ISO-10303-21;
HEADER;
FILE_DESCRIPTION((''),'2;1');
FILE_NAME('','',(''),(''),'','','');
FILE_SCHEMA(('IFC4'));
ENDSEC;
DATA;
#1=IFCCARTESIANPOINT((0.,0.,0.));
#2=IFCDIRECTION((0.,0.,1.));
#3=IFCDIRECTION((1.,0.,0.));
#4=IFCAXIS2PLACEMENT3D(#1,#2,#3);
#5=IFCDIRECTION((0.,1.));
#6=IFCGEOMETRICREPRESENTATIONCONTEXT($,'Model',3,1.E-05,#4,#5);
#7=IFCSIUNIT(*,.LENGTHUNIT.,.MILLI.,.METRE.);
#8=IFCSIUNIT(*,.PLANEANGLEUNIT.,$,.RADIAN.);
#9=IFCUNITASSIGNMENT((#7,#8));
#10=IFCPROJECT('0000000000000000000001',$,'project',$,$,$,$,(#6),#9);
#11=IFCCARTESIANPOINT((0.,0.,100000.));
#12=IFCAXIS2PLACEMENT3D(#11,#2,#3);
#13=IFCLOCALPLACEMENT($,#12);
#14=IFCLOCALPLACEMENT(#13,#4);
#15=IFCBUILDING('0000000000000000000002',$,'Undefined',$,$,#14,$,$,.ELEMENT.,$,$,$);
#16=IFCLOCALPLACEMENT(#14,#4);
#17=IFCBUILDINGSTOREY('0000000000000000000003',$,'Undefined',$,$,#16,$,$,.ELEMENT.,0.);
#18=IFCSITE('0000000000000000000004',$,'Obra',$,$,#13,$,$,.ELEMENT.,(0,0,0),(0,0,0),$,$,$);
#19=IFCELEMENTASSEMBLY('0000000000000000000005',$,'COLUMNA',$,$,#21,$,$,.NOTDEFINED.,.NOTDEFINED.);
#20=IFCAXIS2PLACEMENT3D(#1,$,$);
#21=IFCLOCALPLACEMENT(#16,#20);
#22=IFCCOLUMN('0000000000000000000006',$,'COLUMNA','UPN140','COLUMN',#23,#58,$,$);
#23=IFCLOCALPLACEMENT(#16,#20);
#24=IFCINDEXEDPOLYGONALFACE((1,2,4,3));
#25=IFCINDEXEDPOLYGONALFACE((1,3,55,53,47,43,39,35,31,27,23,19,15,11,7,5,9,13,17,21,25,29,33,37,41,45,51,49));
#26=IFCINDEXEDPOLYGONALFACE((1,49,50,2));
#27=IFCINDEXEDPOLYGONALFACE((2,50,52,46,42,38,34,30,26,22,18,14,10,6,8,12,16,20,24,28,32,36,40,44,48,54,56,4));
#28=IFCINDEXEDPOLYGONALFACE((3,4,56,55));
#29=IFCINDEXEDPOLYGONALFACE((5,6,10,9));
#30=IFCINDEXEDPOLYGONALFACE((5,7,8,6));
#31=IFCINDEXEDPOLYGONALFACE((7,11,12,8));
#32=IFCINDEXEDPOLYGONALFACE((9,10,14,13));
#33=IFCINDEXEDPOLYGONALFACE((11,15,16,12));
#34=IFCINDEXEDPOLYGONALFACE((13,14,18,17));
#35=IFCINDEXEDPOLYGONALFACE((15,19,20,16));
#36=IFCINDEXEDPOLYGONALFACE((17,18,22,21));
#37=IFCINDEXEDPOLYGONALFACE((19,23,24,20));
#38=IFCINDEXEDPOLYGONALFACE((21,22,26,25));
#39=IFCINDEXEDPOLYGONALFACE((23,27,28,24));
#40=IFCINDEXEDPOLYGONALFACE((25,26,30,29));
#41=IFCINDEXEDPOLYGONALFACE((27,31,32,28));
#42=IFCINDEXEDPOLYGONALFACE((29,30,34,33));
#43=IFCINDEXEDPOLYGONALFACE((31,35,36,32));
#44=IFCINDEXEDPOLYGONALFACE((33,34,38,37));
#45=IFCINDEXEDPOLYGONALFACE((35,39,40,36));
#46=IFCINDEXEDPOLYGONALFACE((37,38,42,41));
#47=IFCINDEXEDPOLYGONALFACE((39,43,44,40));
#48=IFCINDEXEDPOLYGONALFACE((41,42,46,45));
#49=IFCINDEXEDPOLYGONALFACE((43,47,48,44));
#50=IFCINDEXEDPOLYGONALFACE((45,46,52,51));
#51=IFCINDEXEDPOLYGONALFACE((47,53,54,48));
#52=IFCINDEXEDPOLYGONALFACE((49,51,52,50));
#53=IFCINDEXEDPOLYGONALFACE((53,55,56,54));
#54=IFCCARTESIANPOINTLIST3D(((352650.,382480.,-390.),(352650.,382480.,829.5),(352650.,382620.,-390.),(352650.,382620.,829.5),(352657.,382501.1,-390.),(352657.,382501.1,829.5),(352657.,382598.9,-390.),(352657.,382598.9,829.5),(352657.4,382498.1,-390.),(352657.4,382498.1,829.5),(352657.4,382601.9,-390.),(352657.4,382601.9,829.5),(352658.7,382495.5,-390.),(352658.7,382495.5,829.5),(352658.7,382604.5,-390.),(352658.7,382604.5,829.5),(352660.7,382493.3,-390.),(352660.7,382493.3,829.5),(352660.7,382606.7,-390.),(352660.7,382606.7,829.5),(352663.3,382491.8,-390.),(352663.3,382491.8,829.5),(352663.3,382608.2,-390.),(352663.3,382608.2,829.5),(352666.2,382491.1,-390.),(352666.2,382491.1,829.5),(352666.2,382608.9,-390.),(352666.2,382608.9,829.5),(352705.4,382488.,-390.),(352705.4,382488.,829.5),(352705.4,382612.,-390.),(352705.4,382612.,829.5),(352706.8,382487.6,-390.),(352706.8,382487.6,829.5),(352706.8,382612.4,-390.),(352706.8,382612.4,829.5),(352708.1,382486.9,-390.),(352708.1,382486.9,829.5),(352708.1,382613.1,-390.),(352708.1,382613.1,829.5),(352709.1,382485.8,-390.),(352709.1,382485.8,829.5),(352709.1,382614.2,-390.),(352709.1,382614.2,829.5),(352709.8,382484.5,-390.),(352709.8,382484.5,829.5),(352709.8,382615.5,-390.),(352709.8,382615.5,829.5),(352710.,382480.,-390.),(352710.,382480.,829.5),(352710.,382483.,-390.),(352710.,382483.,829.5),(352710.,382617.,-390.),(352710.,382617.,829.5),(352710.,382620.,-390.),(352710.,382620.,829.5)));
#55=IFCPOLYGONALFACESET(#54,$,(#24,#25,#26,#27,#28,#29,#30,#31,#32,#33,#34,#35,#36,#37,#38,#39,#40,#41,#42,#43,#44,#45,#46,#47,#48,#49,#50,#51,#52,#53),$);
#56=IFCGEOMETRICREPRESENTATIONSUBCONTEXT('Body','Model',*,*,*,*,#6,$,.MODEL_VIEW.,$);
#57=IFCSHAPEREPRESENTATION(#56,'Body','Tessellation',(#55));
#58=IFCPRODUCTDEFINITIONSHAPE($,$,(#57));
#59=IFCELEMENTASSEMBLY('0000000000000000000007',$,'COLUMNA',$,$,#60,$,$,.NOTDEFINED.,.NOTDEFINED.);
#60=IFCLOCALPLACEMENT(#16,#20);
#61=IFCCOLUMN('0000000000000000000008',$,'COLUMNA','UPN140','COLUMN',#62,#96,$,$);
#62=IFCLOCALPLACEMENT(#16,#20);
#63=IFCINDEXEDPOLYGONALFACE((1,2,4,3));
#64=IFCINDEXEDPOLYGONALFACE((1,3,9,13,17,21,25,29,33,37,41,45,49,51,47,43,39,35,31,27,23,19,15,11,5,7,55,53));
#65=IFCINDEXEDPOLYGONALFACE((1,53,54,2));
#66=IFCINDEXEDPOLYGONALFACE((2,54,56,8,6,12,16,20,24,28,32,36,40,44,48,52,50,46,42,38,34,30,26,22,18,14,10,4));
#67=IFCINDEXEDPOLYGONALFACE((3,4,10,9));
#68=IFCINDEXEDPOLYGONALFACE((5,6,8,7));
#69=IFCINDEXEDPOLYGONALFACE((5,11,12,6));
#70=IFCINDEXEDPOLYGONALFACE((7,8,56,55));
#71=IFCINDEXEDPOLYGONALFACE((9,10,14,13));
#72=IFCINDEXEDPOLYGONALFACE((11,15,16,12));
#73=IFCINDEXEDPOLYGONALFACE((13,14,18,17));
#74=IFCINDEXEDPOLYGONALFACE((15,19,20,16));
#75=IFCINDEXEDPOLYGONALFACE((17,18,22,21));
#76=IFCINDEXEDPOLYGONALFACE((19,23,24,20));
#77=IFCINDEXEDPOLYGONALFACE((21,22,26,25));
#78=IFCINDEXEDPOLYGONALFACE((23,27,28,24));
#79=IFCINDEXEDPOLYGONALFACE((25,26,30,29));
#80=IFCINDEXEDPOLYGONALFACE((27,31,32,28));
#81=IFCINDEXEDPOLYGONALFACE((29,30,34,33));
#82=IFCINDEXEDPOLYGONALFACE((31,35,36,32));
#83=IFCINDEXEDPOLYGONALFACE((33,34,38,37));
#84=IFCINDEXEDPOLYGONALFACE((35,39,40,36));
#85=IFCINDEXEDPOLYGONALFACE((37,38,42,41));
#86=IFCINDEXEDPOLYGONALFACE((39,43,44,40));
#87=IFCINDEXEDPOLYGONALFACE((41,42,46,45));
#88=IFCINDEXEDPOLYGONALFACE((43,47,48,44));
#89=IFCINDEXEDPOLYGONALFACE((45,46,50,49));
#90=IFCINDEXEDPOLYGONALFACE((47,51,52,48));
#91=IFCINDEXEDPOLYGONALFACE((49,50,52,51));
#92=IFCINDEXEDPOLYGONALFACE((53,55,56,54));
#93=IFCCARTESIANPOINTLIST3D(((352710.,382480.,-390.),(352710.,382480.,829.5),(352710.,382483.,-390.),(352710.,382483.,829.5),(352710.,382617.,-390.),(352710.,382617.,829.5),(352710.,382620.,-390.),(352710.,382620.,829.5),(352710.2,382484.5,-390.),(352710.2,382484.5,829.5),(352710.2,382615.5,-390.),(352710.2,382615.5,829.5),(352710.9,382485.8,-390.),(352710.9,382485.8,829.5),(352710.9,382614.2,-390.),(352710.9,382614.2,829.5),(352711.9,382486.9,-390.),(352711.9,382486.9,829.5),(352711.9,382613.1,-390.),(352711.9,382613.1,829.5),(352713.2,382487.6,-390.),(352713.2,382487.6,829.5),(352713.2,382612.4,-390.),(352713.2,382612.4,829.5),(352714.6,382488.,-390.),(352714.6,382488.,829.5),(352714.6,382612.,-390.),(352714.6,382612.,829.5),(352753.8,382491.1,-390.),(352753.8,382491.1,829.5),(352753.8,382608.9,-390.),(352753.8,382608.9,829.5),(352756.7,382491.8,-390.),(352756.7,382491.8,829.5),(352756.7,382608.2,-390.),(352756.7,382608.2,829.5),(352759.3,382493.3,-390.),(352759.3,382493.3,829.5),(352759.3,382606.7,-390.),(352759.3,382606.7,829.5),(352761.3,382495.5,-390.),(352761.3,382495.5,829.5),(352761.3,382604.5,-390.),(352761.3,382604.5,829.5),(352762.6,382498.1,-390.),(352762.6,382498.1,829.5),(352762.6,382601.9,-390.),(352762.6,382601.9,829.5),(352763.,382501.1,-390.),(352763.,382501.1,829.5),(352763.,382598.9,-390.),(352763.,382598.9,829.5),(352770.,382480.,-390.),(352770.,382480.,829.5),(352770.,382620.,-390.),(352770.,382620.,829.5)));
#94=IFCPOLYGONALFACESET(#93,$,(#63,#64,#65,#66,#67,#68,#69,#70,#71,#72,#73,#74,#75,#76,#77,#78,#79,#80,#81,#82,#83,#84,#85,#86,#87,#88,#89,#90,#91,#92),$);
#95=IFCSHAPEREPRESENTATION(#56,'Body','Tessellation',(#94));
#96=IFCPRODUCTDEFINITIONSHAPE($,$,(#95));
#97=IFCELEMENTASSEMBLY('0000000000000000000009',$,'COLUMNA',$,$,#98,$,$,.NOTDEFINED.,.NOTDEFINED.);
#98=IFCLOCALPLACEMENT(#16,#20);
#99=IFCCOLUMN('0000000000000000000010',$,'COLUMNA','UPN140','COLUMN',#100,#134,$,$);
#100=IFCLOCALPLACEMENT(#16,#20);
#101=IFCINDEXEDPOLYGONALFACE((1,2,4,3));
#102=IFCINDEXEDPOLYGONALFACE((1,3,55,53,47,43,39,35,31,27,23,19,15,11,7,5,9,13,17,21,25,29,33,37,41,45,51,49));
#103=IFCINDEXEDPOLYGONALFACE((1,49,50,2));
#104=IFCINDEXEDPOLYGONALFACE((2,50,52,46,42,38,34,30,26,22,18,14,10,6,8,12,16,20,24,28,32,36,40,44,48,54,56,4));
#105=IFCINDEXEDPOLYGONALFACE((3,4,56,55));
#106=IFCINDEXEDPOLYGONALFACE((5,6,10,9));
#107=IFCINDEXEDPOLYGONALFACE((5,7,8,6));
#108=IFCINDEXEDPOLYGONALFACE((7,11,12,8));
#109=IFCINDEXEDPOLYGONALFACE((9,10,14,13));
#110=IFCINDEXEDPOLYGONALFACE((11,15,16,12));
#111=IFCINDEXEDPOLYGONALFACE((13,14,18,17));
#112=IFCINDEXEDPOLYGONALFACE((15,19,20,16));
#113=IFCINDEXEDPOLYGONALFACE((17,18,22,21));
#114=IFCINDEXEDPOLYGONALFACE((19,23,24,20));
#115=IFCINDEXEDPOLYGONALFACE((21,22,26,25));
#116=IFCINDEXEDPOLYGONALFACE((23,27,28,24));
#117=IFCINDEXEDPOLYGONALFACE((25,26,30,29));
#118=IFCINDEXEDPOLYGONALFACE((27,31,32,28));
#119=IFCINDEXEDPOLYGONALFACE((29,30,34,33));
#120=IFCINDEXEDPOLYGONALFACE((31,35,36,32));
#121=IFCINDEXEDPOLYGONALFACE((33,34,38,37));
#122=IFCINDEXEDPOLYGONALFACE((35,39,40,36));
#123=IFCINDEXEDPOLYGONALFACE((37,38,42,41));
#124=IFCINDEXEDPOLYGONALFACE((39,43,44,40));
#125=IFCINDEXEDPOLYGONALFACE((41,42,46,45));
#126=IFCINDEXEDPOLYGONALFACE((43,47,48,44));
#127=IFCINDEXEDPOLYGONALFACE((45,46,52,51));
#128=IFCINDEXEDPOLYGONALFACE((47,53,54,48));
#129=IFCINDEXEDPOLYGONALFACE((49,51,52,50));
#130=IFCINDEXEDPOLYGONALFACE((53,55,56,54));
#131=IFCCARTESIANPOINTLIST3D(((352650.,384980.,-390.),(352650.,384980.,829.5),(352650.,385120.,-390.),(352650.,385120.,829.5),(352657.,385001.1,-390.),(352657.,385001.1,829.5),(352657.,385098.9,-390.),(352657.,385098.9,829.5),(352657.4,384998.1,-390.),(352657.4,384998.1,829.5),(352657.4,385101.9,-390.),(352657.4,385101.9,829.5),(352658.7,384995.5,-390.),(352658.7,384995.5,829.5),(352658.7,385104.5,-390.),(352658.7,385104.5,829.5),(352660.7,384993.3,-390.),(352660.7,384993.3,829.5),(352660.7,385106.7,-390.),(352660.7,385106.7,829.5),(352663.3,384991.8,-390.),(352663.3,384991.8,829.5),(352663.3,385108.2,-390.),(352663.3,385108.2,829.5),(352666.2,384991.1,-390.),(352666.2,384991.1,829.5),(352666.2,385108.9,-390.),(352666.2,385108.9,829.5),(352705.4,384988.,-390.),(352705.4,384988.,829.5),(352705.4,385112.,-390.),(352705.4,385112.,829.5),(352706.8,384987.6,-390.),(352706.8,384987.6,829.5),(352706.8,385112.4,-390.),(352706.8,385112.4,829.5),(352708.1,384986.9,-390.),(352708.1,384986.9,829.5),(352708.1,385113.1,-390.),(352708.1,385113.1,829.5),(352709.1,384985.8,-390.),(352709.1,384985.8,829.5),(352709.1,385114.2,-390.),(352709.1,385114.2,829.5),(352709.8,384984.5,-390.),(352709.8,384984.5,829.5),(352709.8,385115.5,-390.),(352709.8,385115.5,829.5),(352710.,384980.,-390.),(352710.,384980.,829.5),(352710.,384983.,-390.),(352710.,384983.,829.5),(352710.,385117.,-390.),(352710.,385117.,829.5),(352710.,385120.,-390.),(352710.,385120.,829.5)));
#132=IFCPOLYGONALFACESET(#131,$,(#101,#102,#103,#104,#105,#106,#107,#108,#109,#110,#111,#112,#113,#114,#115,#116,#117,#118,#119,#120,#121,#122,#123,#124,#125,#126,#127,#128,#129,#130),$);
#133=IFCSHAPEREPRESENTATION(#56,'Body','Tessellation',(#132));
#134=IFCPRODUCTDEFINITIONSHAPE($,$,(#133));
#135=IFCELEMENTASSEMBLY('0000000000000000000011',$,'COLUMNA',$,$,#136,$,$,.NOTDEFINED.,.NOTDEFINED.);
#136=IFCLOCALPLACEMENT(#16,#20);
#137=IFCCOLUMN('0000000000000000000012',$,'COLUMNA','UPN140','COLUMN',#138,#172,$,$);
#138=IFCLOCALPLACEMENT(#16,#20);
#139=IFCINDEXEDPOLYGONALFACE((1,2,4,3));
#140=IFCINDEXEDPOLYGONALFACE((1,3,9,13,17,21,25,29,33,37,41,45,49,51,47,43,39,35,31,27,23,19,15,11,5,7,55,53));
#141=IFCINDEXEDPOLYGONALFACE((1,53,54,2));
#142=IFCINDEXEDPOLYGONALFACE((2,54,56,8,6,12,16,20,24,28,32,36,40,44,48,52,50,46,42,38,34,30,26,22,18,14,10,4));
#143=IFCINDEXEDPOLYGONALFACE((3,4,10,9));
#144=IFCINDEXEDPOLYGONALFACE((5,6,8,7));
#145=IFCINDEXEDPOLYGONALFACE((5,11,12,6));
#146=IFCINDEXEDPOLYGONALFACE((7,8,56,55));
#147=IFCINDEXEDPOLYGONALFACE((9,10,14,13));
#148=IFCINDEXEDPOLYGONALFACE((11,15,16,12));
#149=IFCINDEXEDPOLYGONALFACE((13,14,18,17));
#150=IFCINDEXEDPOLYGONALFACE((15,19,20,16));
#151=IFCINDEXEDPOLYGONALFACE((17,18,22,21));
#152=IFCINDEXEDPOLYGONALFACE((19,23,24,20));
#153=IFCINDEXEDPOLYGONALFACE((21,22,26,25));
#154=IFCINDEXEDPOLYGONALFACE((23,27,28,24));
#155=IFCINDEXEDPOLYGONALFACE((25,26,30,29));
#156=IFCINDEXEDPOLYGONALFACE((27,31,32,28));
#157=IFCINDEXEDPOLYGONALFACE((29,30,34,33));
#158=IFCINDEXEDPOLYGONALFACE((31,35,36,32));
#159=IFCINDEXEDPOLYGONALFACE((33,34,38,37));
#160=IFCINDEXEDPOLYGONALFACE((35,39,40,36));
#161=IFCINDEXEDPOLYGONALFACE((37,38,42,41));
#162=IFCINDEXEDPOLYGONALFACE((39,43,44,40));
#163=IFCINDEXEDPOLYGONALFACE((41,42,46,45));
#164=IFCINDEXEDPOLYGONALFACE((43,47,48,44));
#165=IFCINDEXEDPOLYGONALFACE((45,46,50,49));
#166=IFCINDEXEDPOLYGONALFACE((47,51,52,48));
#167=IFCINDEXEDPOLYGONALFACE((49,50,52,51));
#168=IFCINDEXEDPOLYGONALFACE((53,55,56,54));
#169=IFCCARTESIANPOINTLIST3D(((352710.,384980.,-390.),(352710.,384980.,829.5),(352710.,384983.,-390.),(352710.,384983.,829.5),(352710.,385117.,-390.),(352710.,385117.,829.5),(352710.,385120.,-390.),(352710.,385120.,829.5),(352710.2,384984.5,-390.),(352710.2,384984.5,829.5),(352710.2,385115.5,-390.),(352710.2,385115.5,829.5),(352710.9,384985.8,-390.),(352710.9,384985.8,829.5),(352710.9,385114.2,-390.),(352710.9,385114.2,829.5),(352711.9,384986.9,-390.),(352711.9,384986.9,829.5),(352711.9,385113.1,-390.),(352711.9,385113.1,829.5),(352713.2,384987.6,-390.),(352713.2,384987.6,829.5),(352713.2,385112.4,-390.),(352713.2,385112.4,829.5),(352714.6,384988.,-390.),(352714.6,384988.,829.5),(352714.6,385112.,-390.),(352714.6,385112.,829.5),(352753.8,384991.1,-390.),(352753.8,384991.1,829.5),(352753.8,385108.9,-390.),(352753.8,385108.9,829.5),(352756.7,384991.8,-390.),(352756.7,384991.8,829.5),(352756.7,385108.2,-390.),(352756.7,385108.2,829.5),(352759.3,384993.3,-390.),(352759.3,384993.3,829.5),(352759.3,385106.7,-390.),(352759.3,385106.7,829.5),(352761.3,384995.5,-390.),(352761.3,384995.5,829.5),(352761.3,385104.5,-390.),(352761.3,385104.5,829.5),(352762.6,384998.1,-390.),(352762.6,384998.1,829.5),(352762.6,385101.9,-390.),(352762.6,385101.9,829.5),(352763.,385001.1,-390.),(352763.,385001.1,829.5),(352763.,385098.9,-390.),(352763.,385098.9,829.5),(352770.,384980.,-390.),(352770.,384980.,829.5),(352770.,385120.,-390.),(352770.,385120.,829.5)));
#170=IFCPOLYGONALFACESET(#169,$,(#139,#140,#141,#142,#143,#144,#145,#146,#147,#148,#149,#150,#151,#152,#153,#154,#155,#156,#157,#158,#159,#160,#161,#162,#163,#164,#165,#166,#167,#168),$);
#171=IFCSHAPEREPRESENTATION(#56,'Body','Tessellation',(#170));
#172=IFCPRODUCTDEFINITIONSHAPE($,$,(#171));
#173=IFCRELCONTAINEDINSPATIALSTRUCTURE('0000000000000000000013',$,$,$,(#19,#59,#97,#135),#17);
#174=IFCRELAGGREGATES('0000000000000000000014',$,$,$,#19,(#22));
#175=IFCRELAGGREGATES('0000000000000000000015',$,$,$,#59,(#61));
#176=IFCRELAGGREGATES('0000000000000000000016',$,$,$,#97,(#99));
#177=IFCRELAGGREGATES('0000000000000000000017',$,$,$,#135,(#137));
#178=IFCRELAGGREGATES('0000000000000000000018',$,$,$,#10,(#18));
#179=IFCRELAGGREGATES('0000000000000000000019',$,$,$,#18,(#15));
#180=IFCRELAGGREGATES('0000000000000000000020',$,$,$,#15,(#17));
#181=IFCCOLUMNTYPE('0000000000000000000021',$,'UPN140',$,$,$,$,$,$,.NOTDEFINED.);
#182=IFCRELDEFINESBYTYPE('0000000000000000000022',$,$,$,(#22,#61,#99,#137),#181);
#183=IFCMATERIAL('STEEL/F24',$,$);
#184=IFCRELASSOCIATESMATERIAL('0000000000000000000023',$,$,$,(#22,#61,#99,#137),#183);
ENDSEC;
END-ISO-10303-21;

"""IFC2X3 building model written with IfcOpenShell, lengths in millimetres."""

from ifc_helpers import new_model, si_unit, direction, frame, origin_with_axes, origin_2d_with_axis, place, context, subcontext, project, spatial, u_section, extrude, material, type_object, element, aggregate, save


model = new_model("IFC2X3")

# Units and contexts
model_context = context("Model", 3, precision=1e-05, world=origin_with_axes(), true_north=direction((0.0, 1.0)))
body_context = subcontext(model_context, "Body", "Model", "MODEL_VIEW")
ifc_project = project(units=[si_unit("LENGTHUNIT", "METRE", prefix="MILLI"), si_unit("PLANEANGLEUNIT", "RADIAN")], contexts=[model_context])

# Site, building, storey
site_placement = place(None, frame((0.0, 0.0, 100000.0), z_axis=(0.0, 0.0, 1.0), x_axis=(1.0, 0.0, 0.0)))
site = spatial("IfcSite", under=ifc_project, at=site_placement, Name="Obra", CompositionType="ELEMENT", RefLatitude=(0, 0, 0), RefLongitude=(0, 0, 0))
building_placement = place(site_placement, origin_with_axes())
building = spatial("IfcBuilding", under=site, at=building_placement, Name="Undefined", CompositionType="ELEMENT")
storey_placement = place(building_placement, origin_with_axes())
storey = spatial("IfcBuildingStorey", under=building, at=storey_placement, Name="Undefined", CompositionType="ELEMENT", Elevation=0.0)

# Element assemblies, columns
ifc_material_1 = material(Name="STEEL/F24")
column_type_1 = type_object("IfcColumnType", Name="UPN140", PredefinedType="NOTDEFINED")
assembly_1_placement = place(storey_placement, origin_with_axes())
assembly_1 = element("IfcElementAssembly", 1, at=assembly_1_placement, inside=storey, Name="COLUMNA", AssemblyPlace="NOTDEFINED", PredefinedType="NOTDEFINED")
column_1_placement = place(assembly_1_placement, frame((352680.0, 382550.0, -390.0), z_axis=(0.0, 0.0, 1.0), x_axis=(0.0, -1.0, 0.0)))
column_1 = element("IfcColumn", 2, at=column_1_placement, type_object=column_type_1, material=ifc_material_1, Name="COLUMNA", Description="UPN140", ObjectType="COLUMN", context=body_context, shape_type="SweptSolid", body=[
    extrude(u_section(Depth=140.0, FlangeWidth=60.0, WebThickness=7.0, FlangeThickness=10.0, FilletRadius=10.0, EdgeRadius=5.0, FlangeSlope=0.07983, at=origin_2d_with_axis()), frame((0.0, 0.0, 1219.5), z_axis=(0.0, 0.0, -1.0), x_axis=(0.0, 1.0, 0.0)), (0.0, 0.0, 1.0), 1219.5),
])
aggregate(assembly_1, [column_1])
assembly_2_placement = place(storey_placement, origin_with_axes())
assembly_2 = element("IfcElementAssembly", 3, at=assembly_2_placement, inside=storey, Name="COLUMNA", AssemblyPlace="NOTDEFINED", PredefinedType="NOTDEFINED")
column_2_placement = place(assembly_2_placement, frame((352740.0, 382550.0, -390.0), z_axis=(0.0, 0.0, 1.0), x_axis=(0.0, 1.0, 0.0)))
column_2 = element("IfcColumn", 4, at=column_2_placement, type_object=column_type_1, material=ifc_material_1, Name="COLUMNA", Description="UPN140", ObjectType="COLUMN", context=body_context, shape_type="SweptSolid", body=[
    extrude(u_section(Depth=140.0, FlangeWidth=60.0, WebThickness=7.0, FlangeThickness=10.0, FilletRadius=10.0, EdgeRadius=5.0, FlangeSlope=0.07983, at=origin_2d_with_axis()), frame((0.0, 0.0, 1219.5), z_axis=(0.0, 0.0, -1.0), x_axis=(0.0, 1.0, 0.0)), (0.0, 0.0, 1.0), 1219.5),
])
aggregate(assembly_2, [column_2])
assembly_3_placement = place(storey_placement, origin_with_axes())
assembly_3 = element("IfcElementAssembly", 5, at=assembly_3_placement, inside=storey, Name="COLUMNA", AssemblyPlace="NOTDEFINED", PredefinedType="NOTDEFINED")
column_3_placement = place(assembly_3_placement, frame((352680.0, 385050.0, -390.0), z_axis=(0.0, 0.0, 1.0), x_axis=(0.0, -1.0, 0.0)))
column_3 = element("IfcColumn", 6, at=column_3_placement, type_object=column_type_1, material=ifc_material_1, Name="COLUMNA", Description="UPN140", ObjectType="COLUMN", context=body_context, shape_type="SweptSolid", body=[
    extrude(u_section(Depth=140.0, FlangeWidth=60.0, WebThickness=7.0, FlangeThickness=10.0, FilletRadius=10.0, EdgeRadius=5.0, FlangeSlope=0.07983, at=origin_2d_with_axis()), frame((0.0, 0.0, 1219.5), z_axis=(0.0, 0.0, -1.0), x_axis=(0.0, 1.0, 0.0)), (0.0, 0.0, 1.0), 1219.5),
])
aggregate(assembly_3, [column_3])
assembly_4_placement = place(storey_placement, origin_with_axes())
assembly_4 = element("IfcElementAssembly", 7, at=assembly_4_placement, inside=storey, Name="COLUMNA", AssemblyPlace="NOTDEFINED", PredefinedType="NOTDEFINED")
column_4_placement = place(assembly_4_placement, frame((352740.0, 385050.0, -390.0), z_axis=(0.0, 0.0, 1.0), x_axis=(0.0, 1.0, 0.0)))
column_4 = element("IfcColumn", 8, at=column_4_placement, type_object=column_type_1, material=ifc_material_1, Name="COLUMNA", Description="UPN140", ObjectType="COLUMN", context=body_context, shape_type="SweptSolid", body=[
    extrude(u_section(Depth=140.0, FlangeWidth=60.0, WebThickness=7.0, FlangeThickness=10.0, FilletRadius=10.0, EdgeRadius=5.0, FlangeSlope=0.07983, at=origin_2d_with_axis()), frame((0.0, 0.0, 1219.5), z_axis=(0.0, 0.0, -1.0), x_axis=(0.0, 1.0, 0.0)), (0.0, 0.0, 1.0), 1219.5),
])
aggregate(assembly_4, [column_4])

save(model, "model.ifc")
